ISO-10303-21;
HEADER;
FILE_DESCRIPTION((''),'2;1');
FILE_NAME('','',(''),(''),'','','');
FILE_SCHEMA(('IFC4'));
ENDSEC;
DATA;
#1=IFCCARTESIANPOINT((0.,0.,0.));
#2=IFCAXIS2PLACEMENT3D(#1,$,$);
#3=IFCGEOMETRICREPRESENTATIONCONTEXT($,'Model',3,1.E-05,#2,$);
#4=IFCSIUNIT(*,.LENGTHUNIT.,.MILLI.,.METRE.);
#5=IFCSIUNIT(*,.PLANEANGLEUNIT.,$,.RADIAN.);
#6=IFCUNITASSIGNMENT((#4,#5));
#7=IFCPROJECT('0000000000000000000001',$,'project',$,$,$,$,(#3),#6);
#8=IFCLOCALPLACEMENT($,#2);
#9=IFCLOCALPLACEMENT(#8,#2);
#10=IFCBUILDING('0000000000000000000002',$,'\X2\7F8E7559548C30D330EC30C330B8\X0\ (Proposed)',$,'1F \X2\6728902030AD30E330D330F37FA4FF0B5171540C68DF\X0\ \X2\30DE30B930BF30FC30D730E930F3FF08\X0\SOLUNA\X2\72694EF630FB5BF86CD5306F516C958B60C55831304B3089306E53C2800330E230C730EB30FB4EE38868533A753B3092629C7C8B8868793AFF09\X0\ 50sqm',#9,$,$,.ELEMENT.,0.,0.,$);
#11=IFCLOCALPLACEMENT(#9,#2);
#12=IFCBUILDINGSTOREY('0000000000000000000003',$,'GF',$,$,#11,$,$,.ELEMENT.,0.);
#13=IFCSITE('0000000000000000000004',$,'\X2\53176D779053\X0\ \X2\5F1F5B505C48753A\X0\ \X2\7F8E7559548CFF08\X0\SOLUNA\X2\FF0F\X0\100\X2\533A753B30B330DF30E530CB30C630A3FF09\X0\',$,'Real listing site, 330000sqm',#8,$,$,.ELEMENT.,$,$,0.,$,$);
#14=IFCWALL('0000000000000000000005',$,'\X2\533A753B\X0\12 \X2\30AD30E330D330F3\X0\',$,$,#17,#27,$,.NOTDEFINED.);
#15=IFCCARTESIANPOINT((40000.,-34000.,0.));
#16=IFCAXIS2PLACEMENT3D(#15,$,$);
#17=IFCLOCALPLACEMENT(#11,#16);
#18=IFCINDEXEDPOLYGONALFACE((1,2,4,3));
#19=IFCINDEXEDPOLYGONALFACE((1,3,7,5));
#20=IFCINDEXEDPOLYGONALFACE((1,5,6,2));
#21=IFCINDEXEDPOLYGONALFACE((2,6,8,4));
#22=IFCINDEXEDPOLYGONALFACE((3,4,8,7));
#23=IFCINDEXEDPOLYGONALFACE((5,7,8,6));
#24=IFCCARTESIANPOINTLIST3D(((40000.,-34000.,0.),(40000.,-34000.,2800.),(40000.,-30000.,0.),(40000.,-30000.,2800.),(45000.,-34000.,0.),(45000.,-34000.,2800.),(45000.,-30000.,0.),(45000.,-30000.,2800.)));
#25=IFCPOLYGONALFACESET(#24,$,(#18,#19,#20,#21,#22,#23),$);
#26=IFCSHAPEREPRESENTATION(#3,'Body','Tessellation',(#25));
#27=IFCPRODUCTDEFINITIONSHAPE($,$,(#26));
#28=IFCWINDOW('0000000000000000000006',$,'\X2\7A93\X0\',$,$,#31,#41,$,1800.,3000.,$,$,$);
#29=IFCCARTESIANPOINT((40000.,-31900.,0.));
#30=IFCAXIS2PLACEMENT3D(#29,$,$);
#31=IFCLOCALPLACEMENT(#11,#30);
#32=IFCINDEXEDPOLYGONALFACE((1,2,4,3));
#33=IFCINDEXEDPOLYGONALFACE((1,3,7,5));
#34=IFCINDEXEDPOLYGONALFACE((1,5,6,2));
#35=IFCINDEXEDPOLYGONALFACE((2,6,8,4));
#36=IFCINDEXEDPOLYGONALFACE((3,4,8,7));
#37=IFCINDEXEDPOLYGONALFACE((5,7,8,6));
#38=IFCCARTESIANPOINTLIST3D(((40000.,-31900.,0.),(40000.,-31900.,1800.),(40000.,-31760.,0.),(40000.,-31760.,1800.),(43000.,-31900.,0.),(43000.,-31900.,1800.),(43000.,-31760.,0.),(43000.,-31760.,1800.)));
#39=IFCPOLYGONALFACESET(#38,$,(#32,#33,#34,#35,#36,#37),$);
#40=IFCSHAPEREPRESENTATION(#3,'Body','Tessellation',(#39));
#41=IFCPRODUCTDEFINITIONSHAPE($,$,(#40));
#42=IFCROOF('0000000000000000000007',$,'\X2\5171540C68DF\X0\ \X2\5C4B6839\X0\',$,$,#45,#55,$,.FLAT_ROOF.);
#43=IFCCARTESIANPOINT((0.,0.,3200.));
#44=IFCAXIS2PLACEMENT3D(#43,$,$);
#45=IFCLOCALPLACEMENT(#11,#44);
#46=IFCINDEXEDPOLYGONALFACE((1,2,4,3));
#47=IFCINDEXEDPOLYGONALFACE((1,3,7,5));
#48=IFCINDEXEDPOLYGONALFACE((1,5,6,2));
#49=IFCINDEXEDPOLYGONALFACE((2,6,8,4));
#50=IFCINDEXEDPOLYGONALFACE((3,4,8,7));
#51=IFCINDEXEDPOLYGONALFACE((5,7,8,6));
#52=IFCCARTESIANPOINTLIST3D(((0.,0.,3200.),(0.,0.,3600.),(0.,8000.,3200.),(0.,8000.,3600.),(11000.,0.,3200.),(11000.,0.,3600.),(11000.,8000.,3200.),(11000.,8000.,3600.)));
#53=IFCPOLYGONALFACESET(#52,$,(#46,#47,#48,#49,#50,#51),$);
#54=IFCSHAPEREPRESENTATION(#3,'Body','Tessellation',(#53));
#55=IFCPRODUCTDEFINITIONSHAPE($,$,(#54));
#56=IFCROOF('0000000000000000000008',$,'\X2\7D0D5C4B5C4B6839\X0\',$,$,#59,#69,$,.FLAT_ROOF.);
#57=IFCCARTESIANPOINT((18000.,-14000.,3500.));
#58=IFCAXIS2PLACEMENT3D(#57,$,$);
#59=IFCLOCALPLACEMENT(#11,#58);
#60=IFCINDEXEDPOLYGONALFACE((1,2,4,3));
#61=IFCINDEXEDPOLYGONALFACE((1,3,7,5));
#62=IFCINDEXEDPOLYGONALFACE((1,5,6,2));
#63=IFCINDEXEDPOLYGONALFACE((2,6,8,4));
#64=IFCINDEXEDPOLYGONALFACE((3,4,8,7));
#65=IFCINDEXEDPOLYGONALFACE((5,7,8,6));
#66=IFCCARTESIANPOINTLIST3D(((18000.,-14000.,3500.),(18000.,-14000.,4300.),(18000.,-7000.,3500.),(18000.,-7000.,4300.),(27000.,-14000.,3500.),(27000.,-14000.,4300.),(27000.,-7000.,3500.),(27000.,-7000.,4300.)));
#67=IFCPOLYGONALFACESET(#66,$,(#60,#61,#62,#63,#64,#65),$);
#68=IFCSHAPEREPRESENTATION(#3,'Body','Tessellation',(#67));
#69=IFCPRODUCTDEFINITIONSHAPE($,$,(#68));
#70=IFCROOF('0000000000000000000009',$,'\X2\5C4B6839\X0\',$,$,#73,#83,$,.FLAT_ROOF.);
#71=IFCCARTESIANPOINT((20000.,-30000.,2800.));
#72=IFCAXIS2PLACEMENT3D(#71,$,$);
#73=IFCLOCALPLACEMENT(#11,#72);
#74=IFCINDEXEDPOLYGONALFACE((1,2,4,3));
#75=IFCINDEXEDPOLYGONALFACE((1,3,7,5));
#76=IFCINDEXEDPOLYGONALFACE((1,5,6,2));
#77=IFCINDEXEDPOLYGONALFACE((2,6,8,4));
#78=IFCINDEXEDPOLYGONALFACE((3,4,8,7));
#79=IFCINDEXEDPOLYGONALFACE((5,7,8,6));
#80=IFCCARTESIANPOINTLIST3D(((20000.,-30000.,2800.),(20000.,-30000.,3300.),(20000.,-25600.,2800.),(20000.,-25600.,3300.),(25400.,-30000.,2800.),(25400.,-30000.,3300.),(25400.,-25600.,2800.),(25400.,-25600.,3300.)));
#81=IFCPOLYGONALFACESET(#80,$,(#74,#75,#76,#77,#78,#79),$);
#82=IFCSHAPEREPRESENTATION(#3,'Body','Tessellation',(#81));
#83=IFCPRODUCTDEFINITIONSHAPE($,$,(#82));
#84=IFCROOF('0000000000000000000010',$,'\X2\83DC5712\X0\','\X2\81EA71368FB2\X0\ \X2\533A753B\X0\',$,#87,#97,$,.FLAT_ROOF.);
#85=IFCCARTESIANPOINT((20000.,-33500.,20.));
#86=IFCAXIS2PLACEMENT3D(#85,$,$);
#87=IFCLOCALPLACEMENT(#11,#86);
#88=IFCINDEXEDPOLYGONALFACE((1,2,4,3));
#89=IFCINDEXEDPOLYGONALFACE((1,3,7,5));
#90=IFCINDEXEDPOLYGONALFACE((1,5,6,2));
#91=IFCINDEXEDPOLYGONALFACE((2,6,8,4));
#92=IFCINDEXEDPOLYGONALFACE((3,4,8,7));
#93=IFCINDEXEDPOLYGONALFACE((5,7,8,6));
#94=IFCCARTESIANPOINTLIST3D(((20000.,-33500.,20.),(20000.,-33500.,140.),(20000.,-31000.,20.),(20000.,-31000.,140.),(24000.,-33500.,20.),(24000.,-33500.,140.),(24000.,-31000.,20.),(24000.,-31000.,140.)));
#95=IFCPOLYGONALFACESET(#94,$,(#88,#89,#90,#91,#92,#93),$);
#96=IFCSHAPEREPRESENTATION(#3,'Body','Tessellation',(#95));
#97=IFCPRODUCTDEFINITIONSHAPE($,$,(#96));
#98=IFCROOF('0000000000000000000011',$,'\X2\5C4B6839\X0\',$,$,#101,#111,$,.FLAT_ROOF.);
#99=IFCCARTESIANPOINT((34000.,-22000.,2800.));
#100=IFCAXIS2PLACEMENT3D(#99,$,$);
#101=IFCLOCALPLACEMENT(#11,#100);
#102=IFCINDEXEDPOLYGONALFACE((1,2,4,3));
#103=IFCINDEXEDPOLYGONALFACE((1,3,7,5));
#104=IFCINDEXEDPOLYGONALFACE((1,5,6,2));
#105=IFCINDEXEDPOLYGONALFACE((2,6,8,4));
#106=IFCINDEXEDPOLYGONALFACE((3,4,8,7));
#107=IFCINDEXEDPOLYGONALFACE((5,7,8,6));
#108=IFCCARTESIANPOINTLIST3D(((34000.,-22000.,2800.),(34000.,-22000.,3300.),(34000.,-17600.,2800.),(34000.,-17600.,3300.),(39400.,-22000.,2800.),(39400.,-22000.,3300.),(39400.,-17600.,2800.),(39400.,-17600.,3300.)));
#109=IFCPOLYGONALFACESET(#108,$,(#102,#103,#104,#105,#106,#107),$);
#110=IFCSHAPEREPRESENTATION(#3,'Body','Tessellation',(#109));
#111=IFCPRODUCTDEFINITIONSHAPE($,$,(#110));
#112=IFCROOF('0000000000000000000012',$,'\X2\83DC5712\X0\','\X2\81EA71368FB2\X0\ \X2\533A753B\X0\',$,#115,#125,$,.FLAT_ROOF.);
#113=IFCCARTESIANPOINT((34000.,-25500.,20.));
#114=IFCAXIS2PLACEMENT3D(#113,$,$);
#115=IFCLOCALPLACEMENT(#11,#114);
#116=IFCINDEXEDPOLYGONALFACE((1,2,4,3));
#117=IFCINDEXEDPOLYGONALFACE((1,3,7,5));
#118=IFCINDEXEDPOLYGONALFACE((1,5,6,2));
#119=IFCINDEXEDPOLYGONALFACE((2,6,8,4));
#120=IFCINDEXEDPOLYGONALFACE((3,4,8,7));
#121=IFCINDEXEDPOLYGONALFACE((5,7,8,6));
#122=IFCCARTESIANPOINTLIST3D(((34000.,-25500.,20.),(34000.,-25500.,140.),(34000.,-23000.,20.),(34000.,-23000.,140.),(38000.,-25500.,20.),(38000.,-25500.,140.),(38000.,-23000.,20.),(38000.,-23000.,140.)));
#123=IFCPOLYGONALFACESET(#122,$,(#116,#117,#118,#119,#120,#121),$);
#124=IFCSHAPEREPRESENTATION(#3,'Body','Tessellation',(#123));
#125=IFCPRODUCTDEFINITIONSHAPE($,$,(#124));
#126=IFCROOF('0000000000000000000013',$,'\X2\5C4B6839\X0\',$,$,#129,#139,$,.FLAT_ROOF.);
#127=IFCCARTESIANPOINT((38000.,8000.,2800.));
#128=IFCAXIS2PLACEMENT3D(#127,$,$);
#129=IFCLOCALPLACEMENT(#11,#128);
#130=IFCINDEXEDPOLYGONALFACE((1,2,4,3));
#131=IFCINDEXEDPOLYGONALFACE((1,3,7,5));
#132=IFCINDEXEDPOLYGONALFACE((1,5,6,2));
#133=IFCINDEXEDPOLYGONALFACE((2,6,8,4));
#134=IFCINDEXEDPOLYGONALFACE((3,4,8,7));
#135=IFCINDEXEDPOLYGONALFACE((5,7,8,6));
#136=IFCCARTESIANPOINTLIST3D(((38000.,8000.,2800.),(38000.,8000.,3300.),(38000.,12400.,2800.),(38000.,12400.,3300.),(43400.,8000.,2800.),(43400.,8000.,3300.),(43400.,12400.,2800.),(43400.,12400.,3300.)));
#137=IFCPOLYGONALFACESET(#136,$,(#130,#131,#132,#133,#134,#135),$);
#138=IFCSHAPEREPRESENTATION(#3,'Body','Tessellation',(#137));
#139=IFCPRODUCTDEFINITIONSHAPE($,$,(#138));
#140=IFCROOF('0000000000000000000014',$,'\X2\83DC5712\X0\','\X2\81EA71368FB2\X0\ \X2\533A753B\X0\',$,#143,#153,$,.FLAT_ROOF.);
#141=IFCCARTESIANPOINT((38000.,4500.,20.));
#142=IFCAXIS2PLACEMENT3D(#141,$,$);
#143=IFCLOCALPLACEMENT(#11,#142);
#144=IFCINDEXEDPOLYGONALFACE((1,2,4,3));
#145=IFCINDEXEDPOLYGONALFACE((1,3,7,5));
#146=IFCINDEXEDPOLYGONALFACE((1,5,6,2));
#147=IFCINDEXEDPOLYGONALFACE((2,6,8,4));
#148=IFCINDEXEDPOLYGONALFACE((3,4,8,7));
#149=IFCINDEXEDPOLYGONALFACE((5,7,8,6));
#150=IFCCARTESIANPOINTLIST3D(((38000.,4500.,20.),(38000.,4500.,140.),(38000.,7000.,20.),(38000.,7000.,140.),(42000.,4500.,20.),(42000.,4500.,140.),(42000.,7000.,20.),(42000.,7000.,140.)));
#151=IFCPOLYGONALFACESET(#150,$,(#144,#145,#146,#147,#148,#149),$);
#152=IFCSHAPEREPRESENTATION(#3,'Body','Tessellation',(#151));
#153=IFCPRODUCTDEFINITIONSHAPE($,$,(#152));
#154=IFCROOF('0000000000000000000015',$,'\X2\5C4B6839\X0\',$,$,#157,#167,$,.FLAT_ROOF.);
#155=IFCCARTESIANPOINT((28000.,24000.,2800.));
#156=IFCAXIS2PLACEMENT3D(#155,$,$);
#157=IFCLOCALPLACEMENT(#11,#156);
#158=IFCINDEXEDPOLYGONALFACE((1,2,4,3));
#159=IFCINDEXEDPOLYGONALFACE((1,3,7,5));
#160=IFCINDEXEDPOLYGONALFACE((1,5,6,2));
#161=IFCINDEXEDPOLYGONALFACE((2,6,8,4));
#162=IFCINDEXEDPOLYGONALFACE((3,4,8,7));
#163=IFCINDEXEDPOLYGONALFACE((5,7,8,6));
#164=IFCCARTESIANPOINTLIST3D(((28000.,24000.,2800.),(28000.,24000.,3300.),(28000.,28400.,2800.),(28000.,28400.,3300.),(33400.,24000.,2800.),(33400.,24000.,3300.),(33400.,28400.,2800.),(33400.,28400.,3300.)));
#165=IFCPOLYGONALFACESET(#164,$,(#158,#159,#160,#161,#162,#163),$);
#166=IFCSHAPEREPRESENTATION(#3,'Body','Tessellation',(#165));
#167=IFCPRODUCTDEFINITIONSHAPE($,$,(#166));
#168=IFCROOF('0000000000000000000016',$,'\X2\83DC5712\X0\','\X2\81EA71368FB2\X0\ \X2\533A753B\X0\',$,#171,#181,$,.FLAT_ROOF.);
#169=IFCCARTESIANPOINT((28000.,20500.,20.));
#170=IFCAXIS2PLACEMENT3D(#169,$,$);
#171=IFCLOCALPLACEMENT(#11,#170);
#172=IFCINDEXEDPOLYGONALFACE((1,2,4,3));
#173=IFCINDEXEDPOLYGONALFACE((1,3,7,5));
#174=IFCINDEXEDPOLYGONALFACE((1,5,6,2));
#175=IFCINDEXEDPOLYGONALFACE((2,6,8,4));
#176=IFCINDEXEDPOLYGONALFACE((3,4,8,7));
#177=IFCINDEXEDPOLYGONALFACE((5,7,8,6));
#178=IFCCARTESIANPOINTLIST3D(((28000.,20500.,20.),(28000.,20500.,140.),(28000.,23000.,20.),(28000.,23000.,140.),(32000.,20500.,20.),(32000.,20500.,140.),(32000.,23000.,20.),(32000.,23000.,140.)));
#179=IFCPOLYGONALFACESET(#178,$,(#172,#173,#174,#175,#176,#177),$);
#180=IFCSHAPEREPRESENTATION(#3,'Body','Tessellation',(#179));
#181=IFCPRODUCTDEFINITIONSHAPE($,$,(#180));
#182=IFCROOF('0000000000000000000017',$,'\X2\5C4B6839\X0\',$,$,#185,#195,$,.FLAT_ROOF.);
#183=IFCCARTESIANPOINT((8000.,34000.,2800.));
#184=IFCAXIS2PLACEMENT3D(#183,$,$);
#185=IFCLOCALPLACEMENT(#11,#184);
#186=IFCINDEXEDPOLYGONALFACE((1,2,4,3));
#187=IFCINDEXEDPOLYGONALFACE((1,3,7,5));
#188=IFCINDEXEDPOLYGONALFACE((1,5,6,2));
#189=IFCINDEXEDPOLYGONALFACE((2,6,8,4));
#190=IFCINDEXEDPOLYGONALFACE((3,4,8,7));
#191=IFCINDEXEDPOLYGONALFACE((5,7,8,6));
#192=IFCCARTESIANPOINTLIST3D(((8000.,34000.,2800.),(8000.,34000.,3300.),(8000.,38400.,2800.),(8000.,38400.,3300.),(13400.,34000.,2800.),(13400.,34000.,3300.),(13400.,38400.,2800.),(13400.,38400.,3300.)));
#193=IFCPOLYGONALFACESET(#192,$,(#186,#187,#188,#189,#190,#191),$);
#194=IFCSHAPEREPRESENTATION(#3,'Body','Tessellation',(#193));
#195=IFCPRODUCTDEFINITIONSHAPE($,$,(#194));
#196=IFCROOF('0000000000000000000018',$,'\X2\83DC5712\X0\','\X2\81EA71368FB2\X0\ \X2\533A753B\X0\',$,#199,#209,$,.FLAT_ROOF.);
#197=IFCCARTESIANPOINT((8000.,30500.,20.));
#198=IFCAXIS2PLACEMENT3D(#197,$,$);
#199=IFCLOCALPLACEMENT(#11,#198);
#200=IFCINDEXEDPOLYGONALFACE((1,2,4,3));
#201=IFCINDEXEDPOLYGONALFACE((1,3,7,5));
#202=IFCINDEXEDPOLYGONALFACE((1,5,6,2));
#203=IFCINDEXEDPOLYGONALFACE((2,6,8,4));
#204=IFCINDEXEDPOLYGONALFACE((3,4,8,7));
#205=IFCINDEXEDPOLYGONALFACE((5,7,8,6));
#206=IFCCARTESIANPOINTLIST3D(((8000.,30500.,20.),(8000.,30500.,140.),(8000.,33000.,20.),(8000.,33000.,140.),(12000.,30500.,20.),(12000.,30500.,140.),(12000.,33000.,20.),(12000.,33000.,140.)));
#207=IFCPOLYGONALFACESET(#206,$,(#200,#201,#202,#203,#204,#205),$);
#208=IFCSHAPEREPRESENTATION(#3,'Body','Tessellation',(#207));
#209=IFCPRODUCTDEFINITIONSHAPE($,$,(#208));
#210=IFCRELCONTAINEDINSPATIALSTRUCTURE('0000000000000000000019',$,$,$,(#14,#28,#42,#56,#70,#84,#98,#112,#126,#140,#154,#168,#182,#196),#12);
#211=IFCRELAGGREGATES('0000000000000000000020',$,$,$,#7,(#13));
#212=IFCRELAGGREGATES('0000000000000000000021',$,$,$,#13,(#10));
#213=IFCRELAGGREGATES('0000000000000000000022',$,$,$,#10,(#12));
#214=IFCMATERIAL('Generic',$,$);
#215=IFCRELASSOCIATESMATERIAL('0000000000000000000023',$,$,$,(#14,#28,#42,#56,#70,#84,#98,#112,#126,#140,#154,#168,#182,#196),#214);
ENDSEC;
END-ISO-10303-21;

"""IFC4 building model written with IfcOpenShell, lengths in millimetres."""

from ifc_helpers import new_model, si_unit, frame, frame_2d, origin, place, context, project, spatial, rectangle, extrude, material, element, fill, save


model = new_model("IFC4")

# Units and contexts
model_context = context("Model", 3, precision=1e-05, world=origin())
ifc_project = project(units=[si_unit("LENGTHUNIT", "METRE", prefix="MILLI"), si_unit("PLANEANGLEUNIT", "RADIAN")], contexts=[model_context])

# Site, building, storey
site_placement = place(None, origin())
site = spatial("IfcSite", under=ifc_project, at=site_placement, Name="北海道 弟子屈町 美留和（SOLUNA／100区画コミュニティ）", ObjectType="Real listing site, 330000sqm", CompositionType="ELEMENT", RefElevation=0.0)
building_placement = place(site_placement, origin())
building = spatial("IfcBuilding", under=site, at=building_placement, Name="美留和ビレッジ (Proposed)", ObjectType="1F 木造キャビン群＋共同棟 マスタープラン（SOLUNA物件・寸法は公開情報からの参考モデル・代表区画を抜粋表示） 50sqm", CompositionType="ELEMENT", ElevationOfRefHeight=0.0, ElevationOfTerrain=0.0)
storey_placement = place(building_placement, origin())
storey = spatial("IfcBuildingStorey", under=building, at=storey_placement, Name="GF", CompositionType="ELEMENT", Elevation=0.0)

# Shared definitions
ifc_material_1 = material(Name="Generic")

# Wall, opening, window
wall_1_placement = place(storey_placement, frame((40000.0, -34000.0, 0.0)))
wall_1 = element("IfcWall", 1, at=wall_1_placement, inside=storey, material=ifc_material_1, Name="区画12 キャビン", PredefinedType="NOTDEFINED", context=model_context, shape_type="SweptSolid", body=[
    extrude(rectangle(XDim=5000.0, YDim=4000.0, at=frame_2d((2500.0, 2000.0))), frame((40000.0, -34000.0, 0.0)), (0.0, 0.0, 1.0), 2800.0),
])
opening_1_placement = place(storey_placement, frame((40000.0, -31900.0, 0.0)))
opening_1 = element("IfcOpeningElement", 2, at=opening_1_placement, cuts=wall_1, PredefinedType="NOTDEFINED", context=model_context, shape_type="SweptSolid", body=[
    extrude(rectangle(XDim=3000.0, YDim=140.0, at=frame_2d((1500.0, 70.0))), frame((40000.0, -31900.0, 0.0)), (0.0, 0.0, 1.0), 1800.0),
])
window_1_placement = place(storey_placement, frame((40000.0, -31900.0, 0.0)))
window_1 = element("IfcWindow", 3, at=window_1_placement, inside=storey, material=ifc_material_1, Name="窓", OverallHeight=1800.0, OverallWidth=3000.0, context=model_context, shape_type="SweptSolid", body=[
    extrude(rectangle(XDim=3000.0, YDim=140.0, at=frame_2d((1500.0, 70.0))), frame((40000.0, -31900.0, 0.0)), (0.0, 0.0, 1.0), 1800.0),
])
fill(opening_1, window_1)

# Roofs
roof_1_placement = place(storey_placement, frame((0.0, 0.0, 3200.0)))
element("IfcRoof", 4, at=roof_1_placement, inside=storey, material=ifc_material_1, Name="共同棟 屋根", PredefinedType="FLAT_ROOF", context=model_context, shape_type="SweptSolid", body=[
    extrude(rectangle(XDim=11000.0, YDim=8000.0, at=frame_2d((5500.0, 4000.0))), frame((0.0, 0.0, 3200.0)), (0.0, 0.0, 1.0), 400.0),
])
roof_2_placement = place(storey_placement, frame((18000.0, -14000.0, 3500.0)))
element("IfcRoof", 5, at=roof_2_placement, inside=storey, material=ifc_material_1, Name="納屋屋根", PredefinedType="FLAT_ROOF", context=model_context, shape_type="SweptSolid", body=[
    extrude(rectangle(XDim=9000.0, YDim=7000.0, at=frame_2d((4500.0, 3500.0))), frame((18000.0, -14000.0, 3500.0)), (0.0, 0.0, 1.0), 800.0),
])
roof_3_placement = place(storey_placement, frame((20000.0, -30000.0, 2800.0)))
element("IfcRoof", 6, at=roof_3_placement, inside=storey, material=ifc_material_1, Name="屋根", PredefinedType="FLAT_ROOF", context=model_context, shape_type="SweptSolid", body=[
    extrude(rectangle(XDim=5400.0, YDim=4400.0, at=frame_2d((2700.0, 2200.0))), frame((20000.0, -30000.0, 2800.0)), (0.0, 0.0, 1.0), 500.0),
])
roof_4_placement = place(storey_placement, frame((20000.0, -33500.0, 20.0)))
element("IfcRoof", 7, at=roof_4_placement, inside=storey, material=ifc_material_1, Name="菜園", Description="自然農 区画", PredefinedType="FLAT_ROOF", context=model_context, shape_type="SweptSolid", body=[
    extrude(rectangle(XDim=4000.0, YDim=2500.0, at=frame_2d((2000.0, 1250.0))), frame((20000.0, -33500.0, 20.0)), (0.0, 0.0, 1.0), 120.0),
])
roof_5_placement = place(storey_placement, frame((34000.0, -22000.0, 2800.0)))
element("IfcRoof", 8, at=roof_5_placement, inside=storey, material=ifc_material_1, Name="屋根", PredefinedType="FLAT_ROOF", context=model_context, shape_type="SweptSolid", body=[
    extrude(rectangle(XDim=5400.0, YDim=4400.0, at=frame_2d((2700.0, 2200.0))), frame((34000.0, -22000.0, 2800.0)), (0.0, 0.0, 1.0), 500.0),
])
roof_6_placement = place(storey_placement, frame((34000.0, -25500.0, 20.0)))
element("IfcRoof", 9, at=roof_6_placement, inside=storey, material=ifc_material_1, Name="菜園", Description="自然農 区画", PredefinedType="FLAT_ROOF", context=model_context, shape_type="SweptSolid", body=[
    extrude(rectangle(XDim=4000.0, YDim=2500.0, at=frame_2d((2000.0, 1250.0))), frame((34000.0, -25500.0, 20.0)), (0.0, 0.0, 1.0), 120.0),
])
roof_7_placement = place(storey_placement, frame((38000.0, 8000.0, 2800.0)))
element("IfcRoof", 10, at=roof_7_placement, inside=storey, material=ifc_material_1, Name="屋根", PredefinedType="FLAT_ROOF", context=model_context, shape_type="SweptSolid", body=[
    extrude(rectangle(XDim=5400.0, YDim=4400.0, at=frame_2d((2700.0, 2200.0))), frame((38000.0, 8000.0, 2800.0)), (0.0, 0.0, 1.0), 500.0),
])
roof_8_placement = place(storey_placement, frame((38000.0, 4500.0, 20.0)))
element("IfcRoof", 11, at=roof_8_placement, inside=storey, material=ifc_material_1, Name="菜園", Description="自然農 区画", PredefinedType="FLAT_ROOF", context=model_context, shape_type="SweptSolid", body=[
    extrude(rectangle(XDim=4000.0, YDim=2500.0, at=frame_2d((2000.0, 1250.0))), frame((38000.0, 4500.0, 20.0)), (0.0, 0.0, 1.0), 120.0),
])
roof_9_placement = place(storey_placement, frame((28000.0, 24000.0, 2800.0)))
element("IfcRoof", 12, at=roof_9_placement, inside=storey, material=ifc_material_1, Name="屋根", PredefinedType="FLAT_ROOF", context=model_context, shape_type="SweptSolid", body=[
    extrude(rectangle(XDim=5400.0, YDim=4400.0, at=frame_2d((2700.0, 2200.0))), frame((28000.0, 24000.0, 2800.0)), (0.0, 0.0, 1.0), 500.0),
])
roof_10_placement = place(storey_placement, frame((28000.0, 20500.0, 20.0)))
element("IfcRoof", 13, at=roof_10_placement, inside=storey, material=ifc_material_1, Name="菜園", Description="自然農 区画", PredefinedType="FLAT_ROOF", context=model_context, shape_type="SweptSolid", body=[
    extrude(rectangle(XDim=4000.0, YDim=2500.0, at=frame_2d((2000.0, 1250.0))), frame((28000.0, 20500.0, 20.0)), (0.0, 0.0, 1.0), 120.0),
])
roof_11_placement = place(storey_placement, frame((8000.0, 34000.0, 2800.0)))
element("IfcRoof", 14, at=roof_11_placement, inside=storey, material=ifc_material_1, Name="屋根", PredefinedType="FLAT_ROOF", context=model_context, shape_type="SweptSolid", body=[
    extrude(rectangle(XDim=5400.0, YDim=4400.0, at=frame_2d((2700.0, 2200.0))), frame((8000.0, 34000.0, 2800.0)), (0.0, 0.0, 1.0), 500.0),
])
roof_12_placement = place(storey_placement, frame((8000.0, 30500.0, 20.0)))
element("IfcRoof", 15, at=roof_12_placement, inside=storey, material=ifc_material_1, Name="菜園", Description="自然農 区画", PredefinedType="FLAT_ROOF", context=model_context, shape_type="SweptSolid", body=[
    extrude(rectangle(XDim=4000.0, YDim=2500.0, at=frame_2d((2000.0, 1250.0))), frame((8000.0, 30500.0, 20.0)), (0.0, 0.0, 1.0), 120.0),
])

save(model, "model.ifc")
